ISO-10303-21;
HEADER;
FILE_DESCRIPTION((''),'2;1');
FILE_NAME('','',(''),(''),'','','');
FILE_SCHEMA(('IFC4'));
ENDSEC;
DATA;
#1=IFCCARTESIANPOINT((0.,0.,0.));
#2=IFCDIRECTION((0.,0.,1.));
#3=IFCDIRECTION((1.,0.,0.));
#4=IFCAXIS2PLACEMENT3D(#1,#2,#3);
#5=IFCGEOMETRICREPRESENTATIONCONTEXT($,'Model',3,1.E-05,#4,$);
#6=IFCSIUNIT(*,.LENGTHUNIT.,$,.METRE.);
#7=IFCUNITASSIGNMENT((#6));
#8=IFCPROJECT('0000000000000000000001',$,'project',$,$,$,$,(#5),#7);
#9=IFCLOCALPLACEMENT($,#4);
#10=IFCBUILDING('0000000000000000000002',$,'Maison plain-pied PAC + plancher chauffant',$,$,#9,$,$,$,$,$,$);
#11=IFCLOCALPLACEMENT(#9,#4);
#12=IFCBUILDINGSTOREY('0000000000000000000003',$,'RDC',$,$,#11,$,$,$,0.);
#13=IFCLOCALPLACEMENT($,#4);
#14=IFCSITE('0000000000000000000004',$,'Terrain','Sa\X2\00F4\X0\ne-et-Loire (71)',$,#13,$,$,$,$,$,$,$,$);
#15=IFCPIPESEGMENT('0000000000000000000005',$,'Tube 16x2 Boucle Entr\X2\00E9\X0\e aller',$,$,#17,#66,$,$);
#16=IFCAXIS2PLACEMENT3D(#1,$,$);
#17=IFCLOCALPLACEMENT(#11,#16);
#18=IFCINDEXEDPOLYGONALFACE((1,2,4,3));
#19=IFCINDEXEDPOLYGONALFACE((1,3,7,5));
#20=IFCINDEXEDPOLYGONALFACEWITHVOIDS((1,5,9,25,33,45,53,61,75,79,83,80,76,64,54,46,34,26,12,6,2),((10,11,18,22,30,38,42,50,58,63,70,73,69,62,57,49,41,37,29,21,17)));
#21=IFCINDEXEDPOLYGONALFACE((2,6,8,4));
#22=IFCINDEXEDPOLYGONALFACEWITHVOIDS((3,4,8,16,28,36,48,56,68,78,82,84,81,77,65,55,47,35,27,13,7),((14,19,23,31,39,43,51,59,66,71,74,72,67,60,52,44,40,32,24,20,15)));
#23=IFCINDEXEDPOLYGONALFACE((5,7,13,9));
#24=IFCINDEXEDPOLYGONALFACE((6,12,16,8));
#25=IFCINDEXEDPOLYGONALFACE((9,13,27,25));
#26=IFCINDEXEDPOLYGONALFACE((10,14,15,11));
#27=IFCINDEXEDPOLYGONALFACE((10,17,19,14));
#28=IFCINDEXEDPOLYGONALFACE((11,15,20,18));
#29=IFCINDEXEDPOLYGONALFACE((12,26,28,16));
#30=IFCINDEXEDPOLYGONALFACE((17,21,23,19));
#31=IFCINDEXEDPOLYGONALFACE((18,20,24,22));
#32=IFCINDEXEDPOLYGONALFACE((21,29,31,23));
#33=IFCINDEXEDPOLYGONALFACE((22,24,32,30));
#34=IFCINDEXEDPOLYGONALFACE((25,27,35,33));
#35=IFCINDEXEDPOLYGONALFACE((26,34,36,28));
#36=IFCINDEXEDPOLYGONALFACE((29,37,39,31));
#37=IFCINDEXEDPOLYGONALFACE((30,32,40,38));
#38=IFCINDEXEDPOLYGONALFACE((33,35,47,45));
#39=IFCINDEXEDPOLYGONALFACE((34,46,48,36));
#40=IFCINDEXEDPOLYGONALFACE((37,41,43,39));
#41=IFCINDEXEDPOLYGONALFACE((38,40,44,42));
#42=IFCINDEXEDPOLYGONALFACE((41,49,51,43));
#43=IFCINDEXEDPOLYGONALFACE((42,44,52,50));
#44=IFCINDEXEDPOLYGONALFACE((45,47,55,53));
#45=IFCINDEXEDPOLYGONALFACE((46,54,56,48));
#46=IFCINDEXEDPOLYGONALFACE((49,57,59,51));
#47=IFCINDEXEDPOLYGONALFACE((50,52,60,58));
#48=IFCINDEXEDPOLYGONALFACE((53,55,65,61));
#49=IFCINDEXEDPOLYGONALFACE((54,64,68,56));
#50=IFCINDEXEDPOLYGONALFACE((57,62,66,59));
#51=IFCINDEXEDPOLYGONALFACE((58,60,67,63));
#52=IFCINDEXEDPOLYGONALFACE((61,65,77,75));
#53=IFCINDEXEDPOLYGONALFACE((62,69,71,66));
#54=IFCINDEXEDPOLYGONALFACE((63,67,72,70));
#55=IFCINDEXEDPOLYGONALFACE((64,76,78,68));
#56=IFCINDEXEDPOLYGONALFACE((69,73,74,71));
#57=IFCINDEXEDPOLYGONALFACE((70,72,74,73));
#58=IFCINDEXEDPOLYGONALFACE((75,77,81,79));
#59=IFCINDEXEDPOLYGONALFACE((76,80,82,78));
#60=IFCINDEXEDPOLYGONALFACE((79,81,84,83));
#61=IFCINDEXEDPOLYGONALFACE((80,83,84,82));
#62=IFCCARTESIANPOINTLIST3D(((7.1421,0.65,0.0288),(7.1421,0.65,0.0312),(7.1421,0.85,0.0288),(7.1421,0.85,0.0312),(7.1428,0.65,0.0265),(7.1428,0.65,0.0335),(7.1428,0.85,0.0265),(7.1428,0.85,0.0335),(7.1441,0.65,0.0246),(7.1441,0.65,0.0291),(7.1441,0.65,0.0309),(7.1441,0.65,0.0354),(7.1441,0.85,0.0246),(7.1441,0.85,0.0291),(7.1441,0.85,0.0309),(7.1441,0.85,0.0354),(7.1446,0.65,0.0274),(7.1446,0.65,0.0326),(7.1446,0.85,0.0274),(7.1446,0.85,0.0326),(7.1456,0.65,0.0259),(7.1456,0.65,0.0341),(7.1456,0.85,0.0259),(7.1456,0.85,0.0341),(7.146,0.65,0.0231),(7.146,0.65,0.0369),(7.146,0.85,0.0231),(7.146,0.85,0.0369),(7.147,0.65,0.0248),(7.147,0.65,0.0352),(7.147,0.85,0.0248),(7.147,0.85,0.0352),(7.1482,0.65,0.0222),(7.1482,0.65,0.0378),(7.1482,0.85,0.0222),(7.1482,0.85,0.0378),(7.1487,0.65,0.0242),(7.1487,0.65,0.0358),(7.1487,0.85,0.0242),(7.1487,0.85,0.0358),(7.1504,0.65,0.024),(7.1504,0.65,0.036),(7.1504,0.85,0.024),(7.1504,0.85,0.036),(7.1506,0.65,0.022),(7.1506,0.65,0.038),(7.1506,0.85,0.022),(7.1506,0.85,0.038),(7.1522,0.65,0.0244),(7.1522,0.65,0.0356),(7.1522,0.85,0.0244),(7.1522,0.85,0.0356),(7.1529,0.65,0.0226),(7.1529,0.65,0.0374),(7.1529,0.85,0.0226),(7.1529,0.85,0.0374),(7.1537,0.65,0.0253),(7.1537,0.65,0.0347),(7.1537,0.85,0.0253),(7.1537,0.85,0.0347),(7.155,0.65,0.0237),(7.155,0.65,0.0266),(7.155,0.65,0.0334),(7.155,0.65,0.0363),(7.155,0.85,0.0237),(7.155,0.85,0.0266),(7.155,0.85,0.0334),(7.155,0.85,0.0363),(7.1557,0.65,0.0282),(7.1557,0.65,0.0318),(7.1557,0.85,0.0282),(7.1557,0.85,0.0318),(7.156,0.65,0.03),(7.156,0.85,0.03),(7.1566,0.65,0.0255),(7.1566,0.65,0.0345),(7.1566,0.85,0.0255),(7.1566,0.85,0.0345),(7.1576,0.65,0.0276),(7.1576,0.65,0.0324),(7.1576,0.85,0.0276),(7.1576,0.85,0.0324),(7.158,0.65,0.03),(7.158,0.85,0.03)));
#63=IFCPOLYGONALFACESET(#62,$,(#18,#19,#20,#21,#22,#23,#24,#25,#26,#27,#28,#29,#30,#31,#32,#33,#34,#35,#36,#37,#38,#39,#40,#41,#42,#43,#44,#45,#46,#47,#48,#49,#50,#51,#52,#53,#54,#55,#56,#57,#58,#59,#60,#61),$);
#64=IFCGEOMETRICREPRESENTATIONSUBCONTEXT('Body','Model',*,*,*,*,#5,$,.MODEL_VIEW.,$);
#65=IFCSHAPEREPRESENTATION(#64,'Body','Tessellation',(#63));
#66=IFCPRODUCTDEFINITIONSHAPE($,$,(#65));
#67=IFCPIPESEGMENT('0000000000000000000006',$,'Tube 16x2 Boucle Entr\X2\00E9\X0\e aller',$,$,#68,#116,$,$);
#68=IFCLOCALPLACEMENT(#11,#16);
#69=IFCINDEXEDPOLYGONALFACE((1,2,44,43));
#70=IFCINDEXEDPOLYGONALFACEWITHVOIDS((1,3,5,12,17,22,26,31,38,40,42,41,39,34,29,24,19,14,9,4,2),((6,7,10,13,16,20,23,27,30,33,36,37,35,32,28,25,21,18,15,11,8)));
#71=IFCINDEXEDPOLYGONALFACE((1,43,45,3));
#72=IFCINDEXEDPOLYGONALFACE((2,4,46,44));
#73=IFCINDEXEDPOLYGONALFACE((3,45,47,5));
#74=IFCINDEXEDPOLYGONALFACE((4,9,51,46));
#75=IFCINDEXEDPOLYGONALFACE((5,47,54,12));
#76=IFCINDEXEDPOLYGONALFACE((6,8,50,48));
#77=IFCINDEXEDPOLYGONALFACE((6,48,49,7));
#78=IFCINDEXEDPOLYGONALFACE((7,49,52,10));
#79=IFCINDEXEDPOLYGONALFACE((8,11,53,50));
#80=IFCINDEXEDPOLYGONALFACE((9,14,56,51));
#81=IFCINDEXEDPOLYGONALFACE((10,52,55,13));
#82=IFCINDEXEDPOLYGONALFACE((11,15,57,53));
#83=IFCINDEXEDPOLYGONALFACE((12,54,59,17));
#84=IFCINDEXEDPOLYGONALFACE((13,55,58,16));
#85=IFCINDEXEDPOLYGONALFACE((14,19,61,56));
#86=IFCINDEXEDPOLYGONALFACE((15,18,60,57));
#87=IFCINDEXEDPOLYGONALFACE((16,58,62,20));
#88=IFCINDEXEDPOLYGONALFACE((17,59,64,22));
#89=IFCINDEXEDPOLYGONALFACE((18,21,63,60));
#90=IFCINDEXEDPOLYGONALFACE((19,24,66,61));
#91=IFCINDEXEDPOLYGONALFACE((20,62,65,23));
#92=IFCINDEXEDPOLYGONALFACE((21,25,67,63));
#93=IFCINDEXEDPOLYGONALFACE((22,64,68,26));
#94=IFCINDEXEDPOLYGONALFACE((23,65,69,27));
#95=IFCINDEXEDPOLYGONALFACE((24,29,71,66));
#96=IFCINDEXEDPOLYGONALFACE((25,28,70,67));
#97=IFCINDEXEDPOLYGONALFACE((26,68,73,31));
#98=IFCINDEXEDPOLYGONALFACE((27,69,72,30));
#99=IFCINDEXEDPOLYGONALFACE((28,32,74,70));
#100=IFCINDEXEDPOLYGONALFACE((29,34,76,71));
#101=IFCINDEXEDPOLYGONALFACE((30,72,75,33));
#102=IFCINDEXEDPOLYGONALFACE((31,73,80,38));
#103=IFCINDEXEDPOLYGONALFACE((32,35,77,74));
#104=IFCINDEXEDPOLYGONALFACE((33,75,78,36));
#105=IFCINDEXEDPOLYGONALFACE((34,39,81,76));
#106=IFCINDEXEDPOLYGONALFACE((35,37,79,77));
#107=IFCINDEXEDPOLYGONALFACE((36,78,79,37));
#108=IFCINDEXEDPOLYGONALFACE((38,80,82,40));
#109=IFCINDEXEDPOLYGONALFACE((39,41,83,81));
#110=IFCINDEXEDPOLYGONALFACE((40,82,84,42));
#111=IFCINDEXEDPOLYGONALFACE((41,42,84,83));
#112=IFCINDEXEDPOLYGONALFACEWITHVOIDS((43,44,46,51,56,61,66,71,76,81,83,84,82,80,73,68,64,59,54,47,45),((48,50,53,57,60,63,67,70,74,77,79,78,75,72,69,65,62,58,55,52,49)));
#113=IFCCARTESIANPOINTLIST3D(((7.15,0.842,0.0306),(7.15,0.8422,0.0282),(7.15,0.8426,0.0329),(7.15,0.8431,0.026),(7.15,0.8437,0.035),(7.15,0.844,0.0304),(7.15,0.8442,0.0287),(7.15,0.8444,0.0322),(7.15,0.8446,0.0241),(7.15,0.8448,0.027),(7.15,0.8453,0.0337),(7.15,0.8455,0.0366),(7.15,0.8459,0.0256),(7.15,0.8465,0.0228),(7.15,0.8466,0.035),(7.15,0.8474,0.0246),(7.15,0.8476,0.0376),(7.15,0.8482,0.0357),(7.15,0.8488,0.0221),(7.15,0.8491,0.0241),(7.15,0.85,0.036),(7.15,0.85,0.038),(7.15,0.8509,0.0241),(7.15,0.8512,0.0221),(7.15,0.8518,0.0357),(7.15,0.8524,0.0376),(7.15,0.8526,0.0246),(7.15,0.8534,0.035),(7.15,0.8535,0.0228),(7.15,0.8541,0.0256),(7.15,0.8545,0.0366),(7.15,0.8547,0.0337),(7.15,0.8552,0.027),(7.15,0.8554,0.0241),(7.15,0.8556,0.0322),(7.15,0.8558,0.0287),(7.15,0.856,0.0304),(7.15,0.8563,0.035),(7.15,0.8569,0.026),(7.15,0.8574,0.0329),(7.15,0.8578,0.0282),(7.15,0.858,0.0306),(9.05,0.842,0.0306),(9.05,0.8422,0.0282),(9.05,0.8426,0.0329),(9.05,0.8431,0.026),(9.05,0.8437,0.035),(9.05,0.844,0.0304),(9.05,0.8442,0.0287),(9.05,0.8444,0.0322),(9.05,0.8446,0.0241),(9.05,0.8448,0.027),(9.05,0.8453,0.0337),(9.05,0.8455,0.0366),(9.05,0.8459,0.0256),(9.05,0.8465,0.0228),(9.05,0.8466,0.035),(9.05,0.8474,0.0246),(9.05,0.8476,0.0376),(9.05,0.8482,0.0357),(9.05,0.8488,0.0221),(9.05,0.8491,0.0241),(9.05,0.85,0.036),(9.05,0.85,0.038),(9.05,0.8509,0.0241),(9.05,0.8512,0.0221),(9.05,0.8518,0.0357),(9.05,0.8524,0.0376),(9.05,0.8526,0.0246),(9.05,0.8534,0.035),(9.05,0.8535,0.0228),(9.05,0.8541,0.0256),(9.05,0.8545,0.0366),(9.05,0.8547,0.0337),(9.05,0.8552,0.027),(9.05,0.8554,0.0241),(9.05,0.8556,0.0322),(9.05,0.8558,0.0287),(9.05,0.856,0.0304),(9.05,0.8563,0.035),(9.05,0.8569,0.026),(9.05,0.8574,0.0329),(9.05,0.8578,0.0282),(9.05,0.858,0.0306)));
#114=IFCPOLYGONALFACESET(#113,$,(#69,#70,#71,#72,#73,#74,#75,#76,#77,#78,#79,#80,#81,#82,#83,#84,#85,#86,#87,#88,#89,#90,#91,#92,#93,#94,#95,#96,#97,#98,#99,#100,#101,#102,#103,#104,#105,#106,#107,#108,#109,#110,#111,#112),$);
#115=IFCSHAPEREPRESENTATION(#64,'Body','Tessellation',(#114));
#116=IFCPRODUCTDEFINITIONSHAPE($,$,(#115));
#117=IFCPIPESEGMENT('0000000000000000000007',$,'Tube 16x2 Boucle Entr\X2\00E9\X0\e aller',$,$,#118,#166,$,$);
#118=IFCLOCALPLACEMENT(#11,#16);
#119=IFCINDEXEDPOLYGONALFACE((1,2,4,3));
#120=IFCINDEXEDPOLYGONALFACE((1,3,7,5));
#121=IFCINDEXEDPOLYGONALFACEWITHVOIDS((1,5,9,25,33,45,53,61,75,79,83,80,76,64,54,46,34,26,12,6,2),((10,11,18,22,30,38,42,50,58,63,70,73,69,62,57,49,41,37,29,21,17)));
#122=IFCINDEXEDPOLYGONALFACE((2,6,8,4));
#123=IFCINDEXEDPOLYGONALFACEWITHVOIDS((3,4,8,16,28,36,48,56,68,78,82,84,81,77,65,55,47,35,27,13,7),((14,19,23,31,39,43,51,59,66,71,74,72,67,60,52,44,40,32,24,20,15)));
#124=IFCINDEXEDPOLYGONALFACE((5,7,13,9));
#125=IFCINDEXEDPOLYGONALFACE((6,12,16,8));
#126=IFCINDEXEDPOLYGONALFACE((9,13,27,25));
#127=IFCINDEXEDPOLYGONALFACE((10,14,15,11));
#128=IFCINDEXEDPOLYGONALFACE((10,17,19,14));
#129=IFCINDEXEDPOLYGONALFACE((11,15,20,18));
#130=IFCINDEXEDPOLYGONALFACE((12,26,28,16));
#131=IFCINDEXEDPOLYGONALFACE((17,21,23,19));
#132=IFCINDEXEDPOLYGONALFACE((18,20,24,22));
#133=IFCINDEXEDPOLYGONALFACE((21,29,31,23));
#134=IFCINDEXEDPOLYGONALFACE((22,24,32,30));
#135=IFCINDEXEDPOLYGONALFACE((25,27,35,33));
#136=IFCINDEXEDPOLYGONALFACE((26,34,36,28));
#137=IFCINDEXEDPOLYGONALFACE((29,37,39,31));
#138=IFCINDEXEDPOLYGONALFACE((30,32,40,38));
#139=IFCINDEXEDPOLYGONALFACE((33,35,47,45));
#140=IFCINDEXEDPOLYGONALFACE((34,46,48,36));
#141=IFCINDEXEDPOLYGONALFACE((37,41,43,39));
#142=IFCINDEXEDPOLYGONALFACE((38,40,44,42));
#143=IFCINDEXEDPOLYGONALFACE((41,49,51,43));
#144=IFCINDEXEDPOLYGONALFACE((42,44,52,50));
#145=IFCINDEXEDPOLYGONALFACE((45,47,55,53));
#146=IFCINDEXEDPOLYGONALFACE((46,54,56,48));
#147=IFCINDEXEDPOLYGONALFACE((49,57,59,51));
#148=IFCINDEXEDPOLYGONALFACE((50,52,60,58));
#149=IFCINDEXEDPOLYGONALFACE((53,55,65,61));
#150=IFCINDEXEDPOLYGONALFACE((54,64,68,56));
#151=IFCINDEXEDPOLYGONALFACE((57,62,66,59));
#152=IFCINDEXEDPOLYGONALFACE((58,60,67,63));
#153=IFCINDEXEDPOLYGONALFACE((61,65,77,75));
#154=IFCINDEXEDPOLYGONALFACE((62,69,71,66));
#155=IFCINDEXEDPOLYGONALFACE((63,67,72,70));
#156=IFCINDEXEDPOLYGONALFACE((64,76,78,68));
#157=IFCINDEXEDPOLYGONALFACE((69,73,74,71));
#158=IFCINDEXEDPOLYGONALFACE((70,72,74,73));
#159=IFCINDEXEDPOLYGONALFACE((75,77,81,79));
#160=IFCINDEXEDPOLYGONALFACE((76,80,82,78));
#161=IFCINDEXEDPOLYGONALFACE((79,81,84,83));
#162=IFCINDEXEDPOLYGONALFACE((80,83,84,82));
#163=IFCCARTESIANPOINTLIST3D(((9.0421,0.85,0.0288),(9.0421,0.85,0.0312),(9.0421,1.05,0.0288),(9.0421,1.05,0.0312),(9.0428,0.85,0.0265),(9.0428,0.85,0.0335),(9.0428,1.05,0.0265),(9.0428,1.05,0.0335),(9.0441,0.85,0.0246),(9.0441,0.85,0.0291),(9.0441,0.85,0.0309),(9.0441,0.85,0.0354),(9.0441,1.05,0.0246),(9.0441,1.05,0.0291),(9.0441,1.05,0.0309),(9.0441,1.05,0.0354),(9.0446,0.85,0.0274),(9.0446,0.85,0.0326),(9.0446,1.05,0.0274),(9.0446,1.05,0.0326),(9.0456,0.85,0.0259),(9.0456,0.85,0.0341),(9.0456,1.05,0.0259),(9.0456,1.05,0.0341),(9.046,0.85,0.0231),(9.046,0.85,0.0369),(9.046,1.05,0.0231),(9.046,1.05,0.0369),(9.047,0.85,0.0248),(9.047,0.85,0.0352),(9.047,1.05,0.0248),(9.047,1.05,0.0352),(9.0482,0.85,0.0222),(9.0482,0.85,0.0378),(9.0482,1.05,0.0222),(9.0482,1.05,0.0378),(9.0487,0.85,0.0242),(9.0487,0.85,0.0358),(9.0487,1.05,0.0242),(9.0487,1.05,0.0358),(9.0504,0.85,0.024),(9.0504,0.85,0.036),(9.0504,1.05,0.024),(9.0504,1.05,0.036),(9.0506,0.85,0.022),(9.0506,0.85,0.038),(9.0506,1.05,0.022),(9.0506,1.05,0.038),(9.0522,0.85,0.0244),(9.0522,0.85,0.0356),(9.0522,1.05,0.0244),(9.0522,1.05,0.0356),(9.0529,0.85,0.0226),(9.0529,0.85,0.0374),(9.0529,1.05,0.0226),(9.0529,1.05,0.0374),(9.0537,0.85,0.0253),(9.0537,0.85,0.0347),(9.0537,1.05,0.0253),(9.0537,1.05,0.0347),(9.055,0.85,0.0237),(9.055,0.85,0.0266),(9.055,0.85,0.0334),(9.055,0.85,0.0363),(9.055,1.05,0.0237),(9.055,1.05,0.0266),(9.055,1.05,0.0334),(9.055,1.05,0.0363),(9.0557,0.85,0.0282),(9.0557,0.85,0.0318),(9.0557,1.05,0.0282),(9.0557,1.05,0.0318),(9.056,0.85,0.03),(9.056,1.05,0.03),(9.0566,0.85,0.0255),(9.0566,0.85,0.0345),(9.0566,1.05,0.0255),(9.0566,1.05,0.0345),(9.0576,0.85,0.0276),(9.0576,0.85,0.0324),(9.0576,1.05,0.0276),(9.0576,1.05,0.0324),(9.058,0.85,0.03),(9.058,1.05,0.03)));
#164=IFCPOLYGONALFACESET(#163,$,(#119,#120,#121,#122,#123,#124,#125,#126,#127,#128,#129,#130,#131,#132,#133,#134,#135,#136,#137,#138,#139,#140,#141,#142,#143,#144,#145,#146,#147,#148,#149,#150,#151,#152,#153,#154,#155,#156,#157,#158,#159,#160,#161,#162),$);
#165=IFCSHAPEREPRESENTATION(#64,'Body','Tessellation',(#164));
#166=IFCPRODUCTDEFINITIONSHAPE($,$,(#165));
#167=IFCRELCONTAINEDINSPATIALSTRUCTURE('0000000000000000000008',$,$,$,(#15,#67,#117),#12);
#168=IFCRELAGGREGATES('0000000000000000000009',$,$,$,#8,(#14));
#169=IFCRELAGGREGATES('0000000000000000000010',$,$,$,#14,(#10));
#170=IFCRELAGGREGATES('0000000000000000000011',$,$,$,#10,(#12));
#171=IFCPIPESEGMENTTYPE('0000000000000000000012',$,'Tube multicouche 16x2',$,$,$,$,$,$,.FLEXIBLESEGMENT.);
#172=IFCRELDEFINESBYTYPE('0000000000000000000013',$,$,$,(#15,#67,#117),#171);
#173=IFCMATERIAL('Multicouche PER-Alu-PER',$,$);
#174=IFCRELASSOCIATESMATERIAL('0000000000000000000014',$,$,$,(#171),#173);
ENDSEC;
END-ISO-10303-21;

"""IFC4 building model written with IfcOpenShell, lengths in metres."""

from ifc_helpers import new_model, si_unit, frame, origin_with_axes, place, context, subcontext, project, spatial, hollow_circle, extrude, material, type_object, element, save


model = new_model("IFC4")

# Units and contexts
model_context = context("Model", 3, precision=1e-05, world=origin_with_axes())
body_context = subcontext(model_context, "Body", "Model", "MODEL_VIEW")
ifc_project = project(units=[si_unit("LENGTHUNIT", "METRE")], contexts=[model_context])

# Site, building, storey
site_placement = place(None, origin_with_axes())
site = spatial("IfcSite", under=ifc_project, at=site_placement, Name="Terrain", Description="Saône-et-Loire (71)")
building_placement = place(None, origin_with_axes())
building = spatial("IfcBuilding", under=site, at=building_placement, Name="Maison plain-pied PAC + plancher chauffant")
storey_placement = place(building_placement, origin_with_axes())
storey = spatial("IfcBuildingStorey", under=building, at=storey_placement, Name="RDC", Elevation=0.0)

# Pipe segments
ifc_material_1 = material(Name="Multicouche PER-Alu-PER")
pipe_segment_type = type_object("IfcPipeSegmentType", Name="Tube multicouche 16x2", PredefinedType="FLEXIBLESEGMENT", material=ifc_material_1)
pipe_segment_1_placement = place(storey_placement, frame((7.15, 0.65, 0.03), z_axis=(0.0, 1.0, 0.0), x_axis=(1.0, 0.0, 0.0)))
element("IfcPipeSegment", 1, at=pipe_segment_1_placement, inside=storey, type_object=pipe_segment_type, Name="Tube 16x2 Boucle Entrée aller", context=body_context, shape_type="SweptSolid", body=[
    extrude(hollow_circle(Radius=0.008, WallThickness=0.002), origin_with_axes(), (0.0, 0.0, 1.0), 0.2),
])
pipe_segment_2_placement = place(storey_placement, frame((7.15, 0.85, 0.03), z_axis=(1.0, 0.0, 0.0), x_axis=(0.0, 0.0, 1.0)))
element("IfcPipeSegment", 2, at=pipe_segment_2_placement, inside=storey, type_object=pipe_segment_type, Name="Tube 16x2 Boucle Entrée aller", context=body_context, shape_type="SweptSolid", body=[
    extrude(hollow_circle(Radius=0.008, WallThickness=0.002), origin_with_axes(), (0.0, 0.0, 1.0), 1.9),
])
pipe_segment_3_placement = place(storey_placement, frame((9.05, 0.85, 0.03), z_axis=(0.0, 1.0, 0.0), x_axis=(1.0, 0.0, 0.0)))
element("IfcPipeSegment", 3, at=pipe_segment_3_placement, inside=storey, type_object=pipe_segment_type, Name="Tube 16x2 Boucle Entrée aller", context=body_context, shape_type="SweptSolid", body=[
    extrude(hollow_circle(Radius=0.008, WallThickness=0.002), origin_with_axes(), (0.0, 0.0, 1.0), 0.2),
])

save(model, "model.ifc")
